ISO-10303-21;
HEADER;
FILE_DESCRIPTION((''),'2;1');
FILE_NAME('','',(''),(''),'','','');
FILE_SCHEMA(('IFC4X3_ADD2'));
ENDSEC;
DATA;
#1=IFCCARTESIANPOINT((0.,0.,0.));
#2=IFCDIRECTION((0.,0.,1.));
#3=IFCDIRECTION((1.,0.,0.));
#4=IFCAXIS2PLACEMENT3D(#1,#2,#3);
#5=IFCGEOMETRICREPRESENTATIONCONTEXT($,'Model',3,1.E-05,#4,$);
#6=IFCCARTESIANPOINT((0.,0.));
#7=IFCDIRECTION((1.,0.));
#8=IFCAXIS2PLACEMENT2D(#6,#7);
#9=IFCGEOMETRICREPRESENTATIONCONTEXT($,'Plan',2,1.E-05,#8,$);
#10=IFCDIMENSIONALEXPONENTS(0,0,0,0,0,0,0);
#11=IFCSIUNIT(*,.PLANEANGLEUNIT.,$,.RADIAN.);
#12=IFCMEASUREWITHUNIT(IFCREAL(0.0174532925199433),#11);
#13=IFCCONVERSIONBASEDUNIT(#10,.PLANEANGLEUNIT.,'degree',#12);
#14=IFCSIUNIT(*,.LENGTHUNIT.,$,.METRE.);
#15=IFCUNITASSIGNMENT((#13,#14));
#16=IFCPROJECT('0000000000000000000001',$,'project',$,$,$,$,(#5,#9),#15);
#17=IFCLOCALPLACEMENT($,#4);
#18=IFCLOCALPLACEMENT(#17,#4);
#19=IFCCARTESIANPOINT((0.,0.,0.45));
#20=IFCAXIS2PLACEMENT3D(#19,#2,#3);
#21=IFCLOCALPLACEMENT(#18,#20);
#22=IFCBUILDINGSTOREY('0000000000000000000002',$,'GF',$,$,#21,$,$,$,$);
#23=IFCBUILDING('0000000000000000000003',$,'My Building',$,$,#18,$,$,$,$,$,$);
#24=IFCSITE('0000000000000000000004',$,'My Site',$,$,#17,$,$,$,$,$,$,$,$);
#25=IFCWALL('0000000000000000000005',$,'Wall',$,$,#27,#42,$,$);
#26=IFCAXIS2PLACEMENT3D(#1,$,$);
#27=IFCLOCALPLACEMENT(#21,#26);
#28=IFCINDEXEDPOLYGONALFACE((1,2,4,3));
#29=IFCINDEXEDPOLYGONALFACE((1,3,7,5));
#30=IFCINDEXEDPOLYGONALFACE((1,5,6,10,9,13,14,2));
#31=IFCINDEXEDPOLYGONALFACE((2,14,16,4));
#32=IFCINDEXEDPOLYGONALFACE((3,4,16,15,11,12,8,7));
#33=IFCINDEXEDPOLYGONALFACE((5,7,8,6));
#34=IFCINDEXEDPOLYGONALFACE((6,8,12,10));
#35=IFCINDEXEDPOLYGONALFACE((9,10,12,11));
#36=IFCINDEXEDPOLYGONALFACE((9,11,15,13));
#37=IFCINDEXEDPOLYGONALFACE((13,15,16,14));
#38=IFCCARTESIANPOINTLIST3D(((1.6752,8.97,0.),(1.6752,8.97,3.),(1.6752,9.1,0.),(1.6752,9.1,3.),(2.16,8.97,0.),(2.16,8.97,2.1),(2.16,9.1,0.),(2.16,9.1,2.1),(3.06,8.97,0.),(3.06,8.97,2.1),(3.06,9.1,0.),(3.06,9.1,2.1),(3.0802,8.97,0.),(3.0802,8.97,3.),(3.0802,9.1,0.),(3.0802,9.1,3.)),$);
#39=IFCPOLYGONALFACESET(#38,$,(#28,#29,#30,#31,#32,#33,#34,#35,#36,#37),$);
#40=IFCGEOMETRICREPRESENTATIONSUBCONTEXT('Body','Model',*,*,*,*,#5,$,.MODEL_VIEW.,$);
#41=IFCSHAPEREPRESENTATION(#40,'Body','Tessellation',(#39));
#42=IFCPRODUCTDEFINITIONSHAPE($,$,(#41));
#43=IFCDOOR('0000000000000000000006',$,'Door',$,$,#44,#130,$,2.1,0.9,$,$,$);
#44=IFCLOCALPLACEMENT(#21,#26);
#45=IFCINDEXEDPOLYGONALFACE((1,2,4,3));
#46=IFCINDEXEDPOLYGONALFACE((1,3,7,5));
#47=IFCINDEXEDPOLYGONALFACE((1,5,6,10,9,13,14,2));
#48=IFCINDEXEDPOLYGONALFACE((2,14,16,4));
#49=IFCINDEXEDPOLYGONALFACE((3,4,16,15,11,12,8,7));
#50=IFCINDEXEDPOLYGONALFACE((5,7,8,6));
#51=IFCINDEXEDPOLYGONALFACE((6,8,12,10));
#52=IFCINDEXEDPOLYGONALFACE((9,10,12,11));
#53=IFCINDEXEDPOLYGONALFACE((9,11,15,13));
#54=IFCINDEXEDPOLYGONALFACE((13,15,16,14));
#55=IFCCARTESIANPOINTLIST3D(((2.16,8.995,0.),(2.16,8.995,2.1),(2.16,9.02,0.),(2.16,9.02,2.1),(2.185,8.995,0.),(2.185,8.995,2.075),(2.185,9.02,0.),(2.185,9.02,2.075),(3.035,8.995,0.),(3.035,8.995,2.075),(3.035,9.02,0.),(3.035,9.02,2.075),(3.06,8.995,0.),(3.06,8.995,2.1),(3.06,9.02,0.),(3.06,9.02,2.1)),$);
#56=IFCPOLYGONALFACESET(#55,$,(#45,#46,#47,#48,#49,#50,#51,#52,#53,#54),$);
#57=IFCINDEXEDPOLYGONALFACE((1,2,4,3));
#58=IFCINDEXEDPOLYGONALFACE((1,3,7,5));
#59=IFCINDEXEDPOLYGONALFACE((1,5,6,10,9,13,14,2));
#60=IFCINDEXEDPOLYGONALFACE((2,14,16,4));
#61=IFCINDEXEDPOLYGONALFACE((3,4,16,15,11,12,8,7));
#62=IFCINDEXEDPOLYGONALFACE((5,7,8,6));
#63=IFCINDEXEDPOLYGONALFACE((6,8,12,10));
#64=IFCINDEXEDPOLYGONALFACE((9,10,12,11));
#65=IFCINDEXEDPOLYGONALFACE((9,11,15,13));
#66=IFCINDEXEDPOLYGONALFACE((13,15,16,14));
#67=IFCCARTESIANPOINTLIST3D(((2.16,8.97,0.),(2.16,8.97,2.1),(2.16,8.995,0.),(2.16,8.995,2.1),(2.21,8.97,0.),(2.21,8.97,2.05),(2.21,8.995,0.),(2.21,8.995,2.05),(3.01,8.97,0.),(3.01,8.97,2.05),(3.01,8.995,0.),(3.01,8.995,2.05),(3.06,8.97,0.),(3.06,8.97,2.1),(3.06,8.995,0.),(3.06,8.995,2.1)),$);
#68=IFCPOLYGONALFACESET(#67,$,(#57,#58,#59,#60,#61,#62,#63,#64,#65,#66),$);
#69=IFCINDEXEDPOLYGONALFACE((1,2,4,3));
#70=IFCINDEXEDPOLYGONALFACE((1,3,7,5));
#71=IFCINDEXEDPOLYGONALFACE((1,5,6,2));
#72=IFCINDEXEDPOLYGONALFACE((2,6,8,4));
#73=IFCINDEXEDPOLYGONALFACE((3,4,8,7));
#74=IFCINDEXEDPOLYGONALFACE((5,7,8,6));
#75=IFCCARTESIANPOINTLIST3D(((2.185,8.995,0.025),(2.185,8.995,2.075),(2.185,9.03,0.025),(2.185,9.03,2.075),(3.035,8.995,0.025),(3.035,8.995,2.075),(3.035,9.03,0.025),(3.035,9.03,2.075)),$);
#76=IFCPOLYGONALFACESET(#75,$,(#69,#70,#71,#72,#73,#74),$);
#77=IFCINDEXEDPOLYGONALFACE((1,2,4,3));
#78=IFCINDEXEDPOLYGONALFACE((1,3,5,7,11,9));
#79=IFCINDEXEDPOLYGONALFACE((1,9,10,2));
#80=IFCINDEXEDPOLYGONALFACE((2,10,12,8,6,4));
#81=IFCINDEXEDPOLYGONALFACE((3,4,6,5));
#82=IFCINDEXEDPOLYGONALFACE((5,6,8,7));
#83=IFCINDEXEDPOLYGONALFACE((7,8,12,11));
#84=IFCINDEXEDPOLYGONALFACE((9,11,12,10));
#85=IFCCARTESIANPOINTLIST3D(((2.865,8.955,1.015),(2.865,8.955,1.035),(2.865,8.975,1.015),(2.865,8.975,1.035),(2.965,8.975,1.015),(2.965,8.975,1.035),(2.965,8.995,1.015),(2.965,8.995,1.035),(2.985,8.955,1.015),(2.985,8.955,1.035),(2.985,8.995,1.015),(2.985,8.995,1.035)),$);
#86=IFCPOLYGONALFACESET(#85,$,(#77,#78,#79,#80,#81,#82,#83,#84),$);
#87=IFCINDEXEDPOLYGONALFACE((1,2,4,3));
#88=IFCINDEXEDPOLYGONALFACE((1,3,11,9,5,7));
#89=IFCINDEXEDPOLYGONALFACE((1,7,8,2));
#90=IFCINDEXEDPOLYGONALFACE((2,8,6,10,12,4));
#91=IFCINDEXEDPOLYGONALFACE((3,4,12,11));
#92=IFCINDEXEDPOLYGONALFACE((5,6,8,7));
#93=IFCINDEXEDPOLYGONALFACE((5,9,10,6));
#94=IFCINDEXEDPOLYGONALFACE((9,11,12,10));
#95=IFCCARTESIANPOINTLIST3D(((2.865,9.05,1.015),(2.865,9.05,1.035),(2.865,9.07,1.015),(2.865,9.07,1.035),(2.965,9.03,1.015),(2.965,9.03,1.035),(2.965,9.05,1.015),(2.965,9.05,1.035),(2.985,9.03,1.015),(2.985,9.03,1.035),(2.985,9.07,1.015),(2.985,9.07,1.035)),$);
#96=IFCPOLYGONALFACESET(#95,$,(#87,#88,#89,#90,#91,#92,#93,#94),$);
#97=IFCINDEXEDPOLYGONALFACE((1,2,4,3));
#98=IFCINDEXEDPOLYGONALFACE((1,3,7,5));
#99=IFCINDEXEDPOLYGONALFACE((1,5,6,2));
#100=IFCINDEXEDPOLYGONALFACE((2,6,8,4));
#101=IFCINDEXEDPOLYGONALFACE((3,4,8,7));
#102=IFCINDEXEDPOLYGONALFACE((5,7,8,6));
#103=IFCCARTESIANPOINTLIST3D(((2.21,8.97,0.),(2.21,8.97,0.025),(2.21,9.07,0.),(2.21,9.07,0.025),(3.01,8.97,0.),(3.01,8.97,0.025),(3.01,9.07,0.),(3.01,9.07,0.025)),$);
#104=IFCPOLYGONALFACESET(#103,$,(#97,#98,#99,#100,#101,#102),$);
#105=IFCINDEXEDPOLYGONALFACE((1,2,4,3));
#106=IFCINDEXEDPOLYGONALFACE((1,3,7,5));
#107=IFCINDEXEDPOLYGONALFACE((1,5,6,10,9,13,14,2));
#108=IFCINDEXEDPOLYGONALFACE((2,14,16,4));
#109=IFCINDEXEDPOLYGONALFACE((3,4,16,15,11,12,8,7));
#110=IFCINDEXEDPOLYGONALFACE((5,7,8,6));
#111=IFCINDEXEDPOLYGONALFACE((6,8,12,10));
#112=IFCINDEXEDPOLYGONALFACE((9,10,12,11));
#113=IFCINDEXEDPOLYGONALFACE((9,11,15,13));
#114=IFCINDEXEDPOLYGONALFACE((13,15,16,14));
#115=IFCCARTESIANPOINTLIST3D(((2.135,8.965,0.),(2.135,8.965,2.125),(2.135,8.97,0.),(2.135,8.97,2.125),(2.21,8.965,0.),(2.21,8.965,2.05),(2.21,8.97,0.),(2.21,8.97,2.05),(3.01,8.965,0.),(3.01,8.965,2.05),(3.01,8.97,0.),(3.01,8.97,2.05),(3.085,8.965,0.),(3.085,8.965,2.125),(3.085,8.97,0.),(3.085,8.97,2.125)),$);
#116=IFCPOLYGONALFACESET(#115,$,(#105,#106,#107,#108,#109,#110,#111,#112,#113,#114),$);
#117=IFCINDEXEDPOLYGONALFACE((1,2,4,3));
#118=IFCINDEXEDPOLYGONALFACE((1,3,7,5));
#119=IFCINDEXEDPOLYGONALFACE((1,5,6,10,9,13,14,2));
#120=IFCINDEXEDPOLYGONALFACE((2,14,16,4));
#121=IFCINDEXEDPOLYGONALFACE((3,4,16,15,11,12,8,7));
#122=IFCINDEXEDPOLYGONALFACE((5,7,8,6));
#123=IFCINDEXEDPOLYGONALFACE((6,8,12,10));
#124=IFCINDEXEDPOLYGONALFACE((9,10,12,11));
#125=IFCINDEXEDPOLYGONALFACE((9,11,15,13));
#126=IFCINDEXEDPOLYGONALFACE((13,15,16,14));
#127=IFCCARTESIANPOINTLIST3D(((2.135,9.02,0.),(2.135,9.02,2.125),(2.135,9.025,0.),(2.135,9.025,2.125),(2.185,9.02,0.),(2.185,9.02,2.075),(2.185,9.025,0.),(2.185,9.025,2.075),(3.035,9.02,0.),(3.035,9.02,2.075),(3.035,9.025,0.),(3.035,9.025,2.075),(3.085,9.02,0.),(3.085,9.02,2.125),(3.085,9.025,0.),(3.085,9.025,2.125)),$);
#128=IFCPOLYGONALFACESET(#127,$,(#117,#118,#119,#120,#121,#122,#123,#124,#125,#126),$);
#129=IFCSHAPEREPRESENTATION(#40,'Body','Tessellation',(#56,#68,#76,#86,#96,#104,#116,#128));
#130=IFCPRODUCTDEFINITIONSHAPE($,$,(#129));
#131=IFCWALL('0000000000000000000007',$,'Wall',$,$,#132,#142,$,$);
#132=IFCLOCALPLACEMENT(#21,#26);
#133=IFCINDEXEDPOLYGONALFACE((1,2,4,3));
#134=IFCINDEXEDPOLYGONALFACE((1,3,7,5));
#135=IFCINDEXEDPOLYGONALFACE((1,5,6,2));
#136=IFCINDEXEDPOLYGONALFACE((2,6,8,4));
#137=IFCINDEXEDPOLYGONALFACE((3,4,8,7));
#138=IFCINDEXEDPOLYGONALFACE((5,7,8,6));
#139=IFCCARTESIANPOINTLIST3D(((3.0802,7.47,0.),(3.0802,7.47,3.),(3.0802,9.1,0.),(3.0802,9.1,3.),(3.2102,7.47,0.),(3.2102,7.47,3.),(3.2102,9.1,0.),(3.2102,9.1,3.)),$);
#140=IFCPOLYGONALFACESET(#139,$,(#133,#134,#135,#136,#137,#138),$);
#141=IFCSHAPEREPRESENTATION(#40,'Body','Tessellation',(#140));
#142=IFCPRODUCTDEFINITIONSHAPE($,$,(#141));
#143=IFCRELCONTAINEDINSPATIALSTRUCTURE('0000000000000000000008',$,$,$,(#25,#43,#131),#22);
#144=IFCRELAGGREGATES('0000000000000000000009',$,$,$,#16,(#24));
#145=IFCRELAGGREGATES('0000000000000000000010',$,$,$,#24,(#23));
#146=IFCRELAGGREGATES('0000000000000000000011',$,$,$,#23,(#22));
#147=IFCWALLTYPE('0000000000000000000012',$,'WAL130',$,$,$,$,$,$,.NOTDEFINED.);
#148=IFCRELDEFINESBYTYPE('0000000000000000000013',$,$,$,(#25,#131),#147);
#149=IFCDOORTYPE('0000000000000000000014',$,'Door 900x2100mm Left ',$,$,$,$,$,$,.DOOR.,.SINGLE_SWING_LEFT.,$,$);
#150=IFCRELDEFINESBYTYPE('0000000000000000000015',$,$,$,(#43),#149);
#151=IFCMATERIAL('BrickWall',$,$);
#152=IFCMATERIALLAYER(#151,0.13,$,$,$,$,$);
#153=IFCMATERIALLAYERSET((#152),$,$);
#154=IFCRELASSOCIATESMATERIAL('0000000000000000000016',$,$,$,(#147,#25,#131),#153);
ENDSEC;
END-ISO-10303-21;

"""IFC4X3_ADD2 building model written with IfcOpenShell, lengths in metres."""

from ifc_helpers import new_model, entity, si_unit, converted_unit, frame, origin_with_axes, origin_2d_with_axis, place, context, subcontext, project, spatial, line, indexed_curve, outline, extrude, shape, source, transform, mapped, material, layer, layer_set, layer_usage, type_object, type_shapes, element, fill, save


model = new_model("IFC4X3_ADD2")

# Units and contexts
model_context = context("Model", 3, precision=1e-05, world=origin_with_axes())
plan_context = context("Plan", 2, precision=1e-05, world=origin_2d_with_axis())
body_context_1 = subcontext(model_context, "Body", "Model", "MODEL_VIEW")
body_context_2 = subcontext(plan_context, "Body", "Plan", "PLAN_VIEW")
ifc_project = project(units=[converted_unit("PLANEANGLEUNIT", "degree", entity("IfcReal", 0.0174532925199433), si_unit("PLANEANGLEUNIT", "RADIAN"), dimensions=[0, 0, 0, 0, 0, 0, 0]), si_unit("LENGTHUNIT", "METRE")], contexts=[model_context, plan_context])

# Site, building, storey
site_placement = place(None, origin_with_axes())
site = spatial("IfcSite", under=ifc_project, at=site_placement, Name="My Site")
building_placement = place(site_placement, origin_with_axes())
building = spatial("IfcBuilding", under=site, at=building_placement, Name="My Building")
storey_placement = place(building_placement, frame((0.0, 0.0, 0.45), z_axis=(0.0, 0.0, 1.0), x_axis=(1.0, 0.0, 0.0)))
storey = spatial("IfcBuildingStorey", under=building, at=storey_placement, Name="GF")

# Shared definitions
ifc_material_1 = material(Name="BrickWall")

# Shared definitions
ifc_layer_1 = layer(ifc_material_1, 0.13)
ifc_layer_set_1 = layer_set([ifc_layer_1])
wall_type_1 = type_object("IfcWallType", Name="WAL130", PredefinedType="NOTDEFINED", material=ifc_layer_set_1)

# Wall, opening, door
ifc_layer_usage_1 = layer_usage(ifc_layer_set_1, "AXIS2", "POSITIVE", 0.0)
wall_1_placement = place(storey_placement, frame((1.6752, 8.97, 0.0), z_axis=(0.0, 0.0, 1.0), x_axis=(1.0, 0.0, 0.0)))
wall_1 = element("IfcWall", 1, at=wall_1_placement, inside=storey, type_object=wall_type_1, material=ifc_layer_usage_1, Name="Wall", context=body_context_1, shape_type="SweptSolid", body=[
    extrude(outline(indexed_curve([(0.0, 0.0), (0.0, 0.13), (1.405, 0.13), (1.405, 0.0), (0.0, 0.0)], self_intersect=False)), origin_with_axes(), (0.0, 0.0, 1.0), 3.0),
])
shared_shape_1 = source(origin_with_axes(), body_context_1, "Body", "SweptSolid", [
    extrude(outline(indexed_curve([(0.0, 0.0), (0.9, 0.0), (0.9, 2.1), (0.0, 2.1)], segments=[line(1, 2, 3, 4, 1)])), frame((0.0, -0.6, 0.0), z_axis=(0.0, -1.0, 0.0), x_axis=(1.0, 0.0, 0.0)), (0.0, 0.0, -1.0), 1.2),
])
opening_1_placement = place(wall_1_placement, frame((0.4847, 0.0, 0.0), z_axis=(0.0, 0.0, 1.0), x_axis=(1.0, 0.0, 0.0)))
opening_1 = element("IfcOpeningElement", 2, at=opening_1_placement, cuts=wall_1, PredefinedType="OPENING", context=body_context_1, shape_type="MappedRepresentation", body=[
    mapped(shared_shape_1, transform((0.0, 0.0, 0.0), x_axis=(1.0, 0.0, 0.0), y_axis=(0.0, 1.0, 0.0), z_axis=(0.0, 0.0, 1.0), scale=1.0)),
])
door_type_1 = type_object("IfcDoorType", Name="Door 900x2100mm Left ", OperationType="SINGLE_SWING_LEFT", PredefinedType="DOOR")
shared_shape_2 = source(origin_with_axes(), body_context_1, "Body", "SweptSolid", [
    extrude(outline(indexed_curve([(0.0, 0.0), (0.0, 2.1), (0.9, 2.1), (0.9, 0.0), (0.875, 0.0), (0.875, 2.075), (0.025, 2.075), (0.025, 0.0)], segments=[line(1, 2, 3, 4, 5, 6, 7, 8, 1)])), frame((0.0, 0.025, 0.0), z_axis=(0.0, -1.0, 0.0), x_axis=(1.0, 0.0, 0.0)), (0.0, 0.0, -1.0), 0.025),
    extrude(outline(indexed_curve([(0.0, 0.0), (0.0, 2.1), (0.9, 2.1), (0.9, 0.0), (0.85, 0.0), (0.85, 2.05), (0.05, 2.05), (0.05, 0.0)], segments=[line(1, 2, 3, 4, 5, 6, 7, 8, 1)])), frame((0.0, 0.0, 0.0), z_axis=(0.0, -1.0, 0.0), x_axis=(1.0, 0.0, 0.0)), (0.0, 0.0, -1.0), 0.025),
    extrude(outline(indexed_curve([(0.0, 0.0), (0.85, 0.0), (0.85, 0.035), (0.0, 0.035)], segments=[line(1, 2, 3, 4, 1)])), frame((0.025, 0.025, 0.025), z_axis=(0.0, 0.0, 1.0), x_axis=(1.0, 0.0, 0.0)), (0.0, 0.0, 1.0), 2.05),
    extrude(outline(indexed_curve([(0.0, 0.0), (0.0, -0.04), (-0.12, -0.04), (-0.12, -0.02), (-0.02, -0.02), (-0.02, 0.0)], segments=[line(1, 2, 3, 4, 5, 6, 1)])), frame((0.825, 0.025, 1.015), z_axis=(0.0, 0.0, 1.0), x_axis=(1.0, 0.0, 0.0)), (0.0, 0.0, 1.0), 0.02),
    extrude(outline(indexed_curve([(0.0, 0.0), (0.0, 0.04), (-0.12, 0.04), (-0.12, 0.02), (-0.02, 0.02), (-0.02, 0.0)], segments=[line(1, 2, 3, 4, 5, 6, 1)])), frame((0.825, 0.06, 1.015), z_axis=(0.0, 0.0, 1.0), x_axis=(1.0, 0.0, 0.0)), (0.0, 0.0, 1.0), 0.02),
    extrude(outline(indexed_curve([(0.0, 0.0), (0.8, 0.0), (0.8, 0.1), (0.0, 0.1)], segments=[line(1, 2, 3, 4, 1)])), frame((0.05, 0.0, 0.0), z_axis=(0.0, 0.0, 1.0), x_axis=(1.0, 0.0, 0.0)), (0.0, 0.0, 1.0), 0.025),
    extrude(outline(indexed_curve([(0.0, 0.0), (0.0, 2.125), (0.95, 2.125), (0.95, 0.0), (0.875, 0.0), (0.875, 2.05), (0.075, 2.05), (0.075, 0.0)], segments=[line(1, 2, 3, 4, 5, 6, 7, 8, 1)])), frame((-0.025, -0.005, 0.0), z_axis=(0.0, -1.0, 0.0), x_axis=(1.0, 0.0, 0.0)), (0.0, 0.0, -1.0), 0.005),
    extrude(outline(indexed_curve([(0.0, 0.0), (0.0, 2.125), (0.95, 2.125), (0.95, 0.0), (0.9, 0.0), (0.9, 2.075), (0.05, 2.075), (0.05, 0.0)], segments=[line(1, 2, 3, 4, 5, 6, 7, 8, 1)])), frame((-0.025, 0.05, 0.0), z_axis=(0.0, -1.0, 0.0), x_axis=(1.0, 0.0, 0.0)), (0.0, 0.0, -1.0), 0.005),
])
shared_shape_3 = source(origin_with_axes(), body_context_2, "Body", "Curve2D", [
    entity("IfcIndexedPolyCurve", entity("IfcCartesianPointList2D", [[0.0, 0.0], [0.0, 0.05], [0.025, 0.05], [0.025, 0.025], [0.05, 0.025], [0.05, 0.0]]), [entity("IfcLineIndex", [1, 2, 3, 4, 5, 6, 1])]),
    entity("IfcIndexedPolyCurve", entity("IfcCartesianPointList2D", [[0.9, 0.0], [0.9, 0.05], [0.875, 0.05], [0.875, 0.025], [0.85, 0.025], [0.85, 0.0]]), [entity("IfcLineIndex", [1, 2, 3, 4, 5, 6, 1])]),
    entity("IfcTrimmedCurve", entity("IfcEllipse", entity("IfcAxis2Placement2D", entity("IfcCartesianPoint", [0.06, 0.05]), entity("IfcDirection", [1.0, 0.0])), 0.815, 0.85), [entity("IfcCartesianPoint", [0.875, 0.05])], [entity("IfcCartesianPoint", [0.06, 0.9])], True, "CARTESIAN"),
    entity("IfcIndexedPolyCurve", entity("IfcCartesianPointList2D", [[0.025, 0.05], [0.06, 0.05], [0.06, 0.9], [0.025, 0.9]]), [entity("IfcLineIndex", [1, 2, 3, 4, 1])]),
])
type_shapes(door_type_1, [shared_shape_2, shared_shape_3])
door_1_placement = place(opening_1_placement, origin_with_axes())
door_1 = element("IfcDoor", 3, at=door_1_placement, inside=storey, type_object=door_type_1, Name="Door", OverallHeight=2.1, OverallWidth=0.9, shapes=[
    shape(body_context_1, "Body", "MappedRepresentation", [mapped(shared_shape_2, transform((0.0, 0.0, 0.0), x_axis=(1.0, 0.0, 0.0), y_axis=(0.0, 1.0, 0.0), z_axis=(0.0, 0.0, 1.0), scale=1.0))]),
    shape(body_context_2, "Body", "MappedRepresentation", [mapped(shared_shape_3, transform((0.0, 0.0, 0.0), x_axis=(1.0, 0.0, 0.0), y_axis=(0.0, 1.0, 0.0), z_axis=(0.0, 0.0, 1.0), scale=1.0))]),
])
fill(opening_1, door_1)

# Wall
ifc_layer_usage_2 = layer_usage(ifc_layer_set_1, "AXIS2", "POSITIVE", 0.0)
wall_2_placement = place(storey_placement, frame((3.2102, 7.47, 0.0), z_axis=(0.0, 0.0, 1.0), x_axis=(0.0, 1.0, 0.0)))
element("IfcWall", 4, at=wall_2_placement, inside=storey, type_object=wall_type_1, material=ifc_layer_usage_2, Name="Wall", context=body_context_1, shape_type="SweptSolid", body=[
    extrude(outline(indexed_curve([(0.0, 0.0), (0.0, 0.13), (1.63, 0.13), (1.63, 0.0), (0.0, 0.0)], self_intersect=False)), origin_with_axes(), (0.0, 0.0, 1.0), 3.0),
])

save(model, "model.ifc")
